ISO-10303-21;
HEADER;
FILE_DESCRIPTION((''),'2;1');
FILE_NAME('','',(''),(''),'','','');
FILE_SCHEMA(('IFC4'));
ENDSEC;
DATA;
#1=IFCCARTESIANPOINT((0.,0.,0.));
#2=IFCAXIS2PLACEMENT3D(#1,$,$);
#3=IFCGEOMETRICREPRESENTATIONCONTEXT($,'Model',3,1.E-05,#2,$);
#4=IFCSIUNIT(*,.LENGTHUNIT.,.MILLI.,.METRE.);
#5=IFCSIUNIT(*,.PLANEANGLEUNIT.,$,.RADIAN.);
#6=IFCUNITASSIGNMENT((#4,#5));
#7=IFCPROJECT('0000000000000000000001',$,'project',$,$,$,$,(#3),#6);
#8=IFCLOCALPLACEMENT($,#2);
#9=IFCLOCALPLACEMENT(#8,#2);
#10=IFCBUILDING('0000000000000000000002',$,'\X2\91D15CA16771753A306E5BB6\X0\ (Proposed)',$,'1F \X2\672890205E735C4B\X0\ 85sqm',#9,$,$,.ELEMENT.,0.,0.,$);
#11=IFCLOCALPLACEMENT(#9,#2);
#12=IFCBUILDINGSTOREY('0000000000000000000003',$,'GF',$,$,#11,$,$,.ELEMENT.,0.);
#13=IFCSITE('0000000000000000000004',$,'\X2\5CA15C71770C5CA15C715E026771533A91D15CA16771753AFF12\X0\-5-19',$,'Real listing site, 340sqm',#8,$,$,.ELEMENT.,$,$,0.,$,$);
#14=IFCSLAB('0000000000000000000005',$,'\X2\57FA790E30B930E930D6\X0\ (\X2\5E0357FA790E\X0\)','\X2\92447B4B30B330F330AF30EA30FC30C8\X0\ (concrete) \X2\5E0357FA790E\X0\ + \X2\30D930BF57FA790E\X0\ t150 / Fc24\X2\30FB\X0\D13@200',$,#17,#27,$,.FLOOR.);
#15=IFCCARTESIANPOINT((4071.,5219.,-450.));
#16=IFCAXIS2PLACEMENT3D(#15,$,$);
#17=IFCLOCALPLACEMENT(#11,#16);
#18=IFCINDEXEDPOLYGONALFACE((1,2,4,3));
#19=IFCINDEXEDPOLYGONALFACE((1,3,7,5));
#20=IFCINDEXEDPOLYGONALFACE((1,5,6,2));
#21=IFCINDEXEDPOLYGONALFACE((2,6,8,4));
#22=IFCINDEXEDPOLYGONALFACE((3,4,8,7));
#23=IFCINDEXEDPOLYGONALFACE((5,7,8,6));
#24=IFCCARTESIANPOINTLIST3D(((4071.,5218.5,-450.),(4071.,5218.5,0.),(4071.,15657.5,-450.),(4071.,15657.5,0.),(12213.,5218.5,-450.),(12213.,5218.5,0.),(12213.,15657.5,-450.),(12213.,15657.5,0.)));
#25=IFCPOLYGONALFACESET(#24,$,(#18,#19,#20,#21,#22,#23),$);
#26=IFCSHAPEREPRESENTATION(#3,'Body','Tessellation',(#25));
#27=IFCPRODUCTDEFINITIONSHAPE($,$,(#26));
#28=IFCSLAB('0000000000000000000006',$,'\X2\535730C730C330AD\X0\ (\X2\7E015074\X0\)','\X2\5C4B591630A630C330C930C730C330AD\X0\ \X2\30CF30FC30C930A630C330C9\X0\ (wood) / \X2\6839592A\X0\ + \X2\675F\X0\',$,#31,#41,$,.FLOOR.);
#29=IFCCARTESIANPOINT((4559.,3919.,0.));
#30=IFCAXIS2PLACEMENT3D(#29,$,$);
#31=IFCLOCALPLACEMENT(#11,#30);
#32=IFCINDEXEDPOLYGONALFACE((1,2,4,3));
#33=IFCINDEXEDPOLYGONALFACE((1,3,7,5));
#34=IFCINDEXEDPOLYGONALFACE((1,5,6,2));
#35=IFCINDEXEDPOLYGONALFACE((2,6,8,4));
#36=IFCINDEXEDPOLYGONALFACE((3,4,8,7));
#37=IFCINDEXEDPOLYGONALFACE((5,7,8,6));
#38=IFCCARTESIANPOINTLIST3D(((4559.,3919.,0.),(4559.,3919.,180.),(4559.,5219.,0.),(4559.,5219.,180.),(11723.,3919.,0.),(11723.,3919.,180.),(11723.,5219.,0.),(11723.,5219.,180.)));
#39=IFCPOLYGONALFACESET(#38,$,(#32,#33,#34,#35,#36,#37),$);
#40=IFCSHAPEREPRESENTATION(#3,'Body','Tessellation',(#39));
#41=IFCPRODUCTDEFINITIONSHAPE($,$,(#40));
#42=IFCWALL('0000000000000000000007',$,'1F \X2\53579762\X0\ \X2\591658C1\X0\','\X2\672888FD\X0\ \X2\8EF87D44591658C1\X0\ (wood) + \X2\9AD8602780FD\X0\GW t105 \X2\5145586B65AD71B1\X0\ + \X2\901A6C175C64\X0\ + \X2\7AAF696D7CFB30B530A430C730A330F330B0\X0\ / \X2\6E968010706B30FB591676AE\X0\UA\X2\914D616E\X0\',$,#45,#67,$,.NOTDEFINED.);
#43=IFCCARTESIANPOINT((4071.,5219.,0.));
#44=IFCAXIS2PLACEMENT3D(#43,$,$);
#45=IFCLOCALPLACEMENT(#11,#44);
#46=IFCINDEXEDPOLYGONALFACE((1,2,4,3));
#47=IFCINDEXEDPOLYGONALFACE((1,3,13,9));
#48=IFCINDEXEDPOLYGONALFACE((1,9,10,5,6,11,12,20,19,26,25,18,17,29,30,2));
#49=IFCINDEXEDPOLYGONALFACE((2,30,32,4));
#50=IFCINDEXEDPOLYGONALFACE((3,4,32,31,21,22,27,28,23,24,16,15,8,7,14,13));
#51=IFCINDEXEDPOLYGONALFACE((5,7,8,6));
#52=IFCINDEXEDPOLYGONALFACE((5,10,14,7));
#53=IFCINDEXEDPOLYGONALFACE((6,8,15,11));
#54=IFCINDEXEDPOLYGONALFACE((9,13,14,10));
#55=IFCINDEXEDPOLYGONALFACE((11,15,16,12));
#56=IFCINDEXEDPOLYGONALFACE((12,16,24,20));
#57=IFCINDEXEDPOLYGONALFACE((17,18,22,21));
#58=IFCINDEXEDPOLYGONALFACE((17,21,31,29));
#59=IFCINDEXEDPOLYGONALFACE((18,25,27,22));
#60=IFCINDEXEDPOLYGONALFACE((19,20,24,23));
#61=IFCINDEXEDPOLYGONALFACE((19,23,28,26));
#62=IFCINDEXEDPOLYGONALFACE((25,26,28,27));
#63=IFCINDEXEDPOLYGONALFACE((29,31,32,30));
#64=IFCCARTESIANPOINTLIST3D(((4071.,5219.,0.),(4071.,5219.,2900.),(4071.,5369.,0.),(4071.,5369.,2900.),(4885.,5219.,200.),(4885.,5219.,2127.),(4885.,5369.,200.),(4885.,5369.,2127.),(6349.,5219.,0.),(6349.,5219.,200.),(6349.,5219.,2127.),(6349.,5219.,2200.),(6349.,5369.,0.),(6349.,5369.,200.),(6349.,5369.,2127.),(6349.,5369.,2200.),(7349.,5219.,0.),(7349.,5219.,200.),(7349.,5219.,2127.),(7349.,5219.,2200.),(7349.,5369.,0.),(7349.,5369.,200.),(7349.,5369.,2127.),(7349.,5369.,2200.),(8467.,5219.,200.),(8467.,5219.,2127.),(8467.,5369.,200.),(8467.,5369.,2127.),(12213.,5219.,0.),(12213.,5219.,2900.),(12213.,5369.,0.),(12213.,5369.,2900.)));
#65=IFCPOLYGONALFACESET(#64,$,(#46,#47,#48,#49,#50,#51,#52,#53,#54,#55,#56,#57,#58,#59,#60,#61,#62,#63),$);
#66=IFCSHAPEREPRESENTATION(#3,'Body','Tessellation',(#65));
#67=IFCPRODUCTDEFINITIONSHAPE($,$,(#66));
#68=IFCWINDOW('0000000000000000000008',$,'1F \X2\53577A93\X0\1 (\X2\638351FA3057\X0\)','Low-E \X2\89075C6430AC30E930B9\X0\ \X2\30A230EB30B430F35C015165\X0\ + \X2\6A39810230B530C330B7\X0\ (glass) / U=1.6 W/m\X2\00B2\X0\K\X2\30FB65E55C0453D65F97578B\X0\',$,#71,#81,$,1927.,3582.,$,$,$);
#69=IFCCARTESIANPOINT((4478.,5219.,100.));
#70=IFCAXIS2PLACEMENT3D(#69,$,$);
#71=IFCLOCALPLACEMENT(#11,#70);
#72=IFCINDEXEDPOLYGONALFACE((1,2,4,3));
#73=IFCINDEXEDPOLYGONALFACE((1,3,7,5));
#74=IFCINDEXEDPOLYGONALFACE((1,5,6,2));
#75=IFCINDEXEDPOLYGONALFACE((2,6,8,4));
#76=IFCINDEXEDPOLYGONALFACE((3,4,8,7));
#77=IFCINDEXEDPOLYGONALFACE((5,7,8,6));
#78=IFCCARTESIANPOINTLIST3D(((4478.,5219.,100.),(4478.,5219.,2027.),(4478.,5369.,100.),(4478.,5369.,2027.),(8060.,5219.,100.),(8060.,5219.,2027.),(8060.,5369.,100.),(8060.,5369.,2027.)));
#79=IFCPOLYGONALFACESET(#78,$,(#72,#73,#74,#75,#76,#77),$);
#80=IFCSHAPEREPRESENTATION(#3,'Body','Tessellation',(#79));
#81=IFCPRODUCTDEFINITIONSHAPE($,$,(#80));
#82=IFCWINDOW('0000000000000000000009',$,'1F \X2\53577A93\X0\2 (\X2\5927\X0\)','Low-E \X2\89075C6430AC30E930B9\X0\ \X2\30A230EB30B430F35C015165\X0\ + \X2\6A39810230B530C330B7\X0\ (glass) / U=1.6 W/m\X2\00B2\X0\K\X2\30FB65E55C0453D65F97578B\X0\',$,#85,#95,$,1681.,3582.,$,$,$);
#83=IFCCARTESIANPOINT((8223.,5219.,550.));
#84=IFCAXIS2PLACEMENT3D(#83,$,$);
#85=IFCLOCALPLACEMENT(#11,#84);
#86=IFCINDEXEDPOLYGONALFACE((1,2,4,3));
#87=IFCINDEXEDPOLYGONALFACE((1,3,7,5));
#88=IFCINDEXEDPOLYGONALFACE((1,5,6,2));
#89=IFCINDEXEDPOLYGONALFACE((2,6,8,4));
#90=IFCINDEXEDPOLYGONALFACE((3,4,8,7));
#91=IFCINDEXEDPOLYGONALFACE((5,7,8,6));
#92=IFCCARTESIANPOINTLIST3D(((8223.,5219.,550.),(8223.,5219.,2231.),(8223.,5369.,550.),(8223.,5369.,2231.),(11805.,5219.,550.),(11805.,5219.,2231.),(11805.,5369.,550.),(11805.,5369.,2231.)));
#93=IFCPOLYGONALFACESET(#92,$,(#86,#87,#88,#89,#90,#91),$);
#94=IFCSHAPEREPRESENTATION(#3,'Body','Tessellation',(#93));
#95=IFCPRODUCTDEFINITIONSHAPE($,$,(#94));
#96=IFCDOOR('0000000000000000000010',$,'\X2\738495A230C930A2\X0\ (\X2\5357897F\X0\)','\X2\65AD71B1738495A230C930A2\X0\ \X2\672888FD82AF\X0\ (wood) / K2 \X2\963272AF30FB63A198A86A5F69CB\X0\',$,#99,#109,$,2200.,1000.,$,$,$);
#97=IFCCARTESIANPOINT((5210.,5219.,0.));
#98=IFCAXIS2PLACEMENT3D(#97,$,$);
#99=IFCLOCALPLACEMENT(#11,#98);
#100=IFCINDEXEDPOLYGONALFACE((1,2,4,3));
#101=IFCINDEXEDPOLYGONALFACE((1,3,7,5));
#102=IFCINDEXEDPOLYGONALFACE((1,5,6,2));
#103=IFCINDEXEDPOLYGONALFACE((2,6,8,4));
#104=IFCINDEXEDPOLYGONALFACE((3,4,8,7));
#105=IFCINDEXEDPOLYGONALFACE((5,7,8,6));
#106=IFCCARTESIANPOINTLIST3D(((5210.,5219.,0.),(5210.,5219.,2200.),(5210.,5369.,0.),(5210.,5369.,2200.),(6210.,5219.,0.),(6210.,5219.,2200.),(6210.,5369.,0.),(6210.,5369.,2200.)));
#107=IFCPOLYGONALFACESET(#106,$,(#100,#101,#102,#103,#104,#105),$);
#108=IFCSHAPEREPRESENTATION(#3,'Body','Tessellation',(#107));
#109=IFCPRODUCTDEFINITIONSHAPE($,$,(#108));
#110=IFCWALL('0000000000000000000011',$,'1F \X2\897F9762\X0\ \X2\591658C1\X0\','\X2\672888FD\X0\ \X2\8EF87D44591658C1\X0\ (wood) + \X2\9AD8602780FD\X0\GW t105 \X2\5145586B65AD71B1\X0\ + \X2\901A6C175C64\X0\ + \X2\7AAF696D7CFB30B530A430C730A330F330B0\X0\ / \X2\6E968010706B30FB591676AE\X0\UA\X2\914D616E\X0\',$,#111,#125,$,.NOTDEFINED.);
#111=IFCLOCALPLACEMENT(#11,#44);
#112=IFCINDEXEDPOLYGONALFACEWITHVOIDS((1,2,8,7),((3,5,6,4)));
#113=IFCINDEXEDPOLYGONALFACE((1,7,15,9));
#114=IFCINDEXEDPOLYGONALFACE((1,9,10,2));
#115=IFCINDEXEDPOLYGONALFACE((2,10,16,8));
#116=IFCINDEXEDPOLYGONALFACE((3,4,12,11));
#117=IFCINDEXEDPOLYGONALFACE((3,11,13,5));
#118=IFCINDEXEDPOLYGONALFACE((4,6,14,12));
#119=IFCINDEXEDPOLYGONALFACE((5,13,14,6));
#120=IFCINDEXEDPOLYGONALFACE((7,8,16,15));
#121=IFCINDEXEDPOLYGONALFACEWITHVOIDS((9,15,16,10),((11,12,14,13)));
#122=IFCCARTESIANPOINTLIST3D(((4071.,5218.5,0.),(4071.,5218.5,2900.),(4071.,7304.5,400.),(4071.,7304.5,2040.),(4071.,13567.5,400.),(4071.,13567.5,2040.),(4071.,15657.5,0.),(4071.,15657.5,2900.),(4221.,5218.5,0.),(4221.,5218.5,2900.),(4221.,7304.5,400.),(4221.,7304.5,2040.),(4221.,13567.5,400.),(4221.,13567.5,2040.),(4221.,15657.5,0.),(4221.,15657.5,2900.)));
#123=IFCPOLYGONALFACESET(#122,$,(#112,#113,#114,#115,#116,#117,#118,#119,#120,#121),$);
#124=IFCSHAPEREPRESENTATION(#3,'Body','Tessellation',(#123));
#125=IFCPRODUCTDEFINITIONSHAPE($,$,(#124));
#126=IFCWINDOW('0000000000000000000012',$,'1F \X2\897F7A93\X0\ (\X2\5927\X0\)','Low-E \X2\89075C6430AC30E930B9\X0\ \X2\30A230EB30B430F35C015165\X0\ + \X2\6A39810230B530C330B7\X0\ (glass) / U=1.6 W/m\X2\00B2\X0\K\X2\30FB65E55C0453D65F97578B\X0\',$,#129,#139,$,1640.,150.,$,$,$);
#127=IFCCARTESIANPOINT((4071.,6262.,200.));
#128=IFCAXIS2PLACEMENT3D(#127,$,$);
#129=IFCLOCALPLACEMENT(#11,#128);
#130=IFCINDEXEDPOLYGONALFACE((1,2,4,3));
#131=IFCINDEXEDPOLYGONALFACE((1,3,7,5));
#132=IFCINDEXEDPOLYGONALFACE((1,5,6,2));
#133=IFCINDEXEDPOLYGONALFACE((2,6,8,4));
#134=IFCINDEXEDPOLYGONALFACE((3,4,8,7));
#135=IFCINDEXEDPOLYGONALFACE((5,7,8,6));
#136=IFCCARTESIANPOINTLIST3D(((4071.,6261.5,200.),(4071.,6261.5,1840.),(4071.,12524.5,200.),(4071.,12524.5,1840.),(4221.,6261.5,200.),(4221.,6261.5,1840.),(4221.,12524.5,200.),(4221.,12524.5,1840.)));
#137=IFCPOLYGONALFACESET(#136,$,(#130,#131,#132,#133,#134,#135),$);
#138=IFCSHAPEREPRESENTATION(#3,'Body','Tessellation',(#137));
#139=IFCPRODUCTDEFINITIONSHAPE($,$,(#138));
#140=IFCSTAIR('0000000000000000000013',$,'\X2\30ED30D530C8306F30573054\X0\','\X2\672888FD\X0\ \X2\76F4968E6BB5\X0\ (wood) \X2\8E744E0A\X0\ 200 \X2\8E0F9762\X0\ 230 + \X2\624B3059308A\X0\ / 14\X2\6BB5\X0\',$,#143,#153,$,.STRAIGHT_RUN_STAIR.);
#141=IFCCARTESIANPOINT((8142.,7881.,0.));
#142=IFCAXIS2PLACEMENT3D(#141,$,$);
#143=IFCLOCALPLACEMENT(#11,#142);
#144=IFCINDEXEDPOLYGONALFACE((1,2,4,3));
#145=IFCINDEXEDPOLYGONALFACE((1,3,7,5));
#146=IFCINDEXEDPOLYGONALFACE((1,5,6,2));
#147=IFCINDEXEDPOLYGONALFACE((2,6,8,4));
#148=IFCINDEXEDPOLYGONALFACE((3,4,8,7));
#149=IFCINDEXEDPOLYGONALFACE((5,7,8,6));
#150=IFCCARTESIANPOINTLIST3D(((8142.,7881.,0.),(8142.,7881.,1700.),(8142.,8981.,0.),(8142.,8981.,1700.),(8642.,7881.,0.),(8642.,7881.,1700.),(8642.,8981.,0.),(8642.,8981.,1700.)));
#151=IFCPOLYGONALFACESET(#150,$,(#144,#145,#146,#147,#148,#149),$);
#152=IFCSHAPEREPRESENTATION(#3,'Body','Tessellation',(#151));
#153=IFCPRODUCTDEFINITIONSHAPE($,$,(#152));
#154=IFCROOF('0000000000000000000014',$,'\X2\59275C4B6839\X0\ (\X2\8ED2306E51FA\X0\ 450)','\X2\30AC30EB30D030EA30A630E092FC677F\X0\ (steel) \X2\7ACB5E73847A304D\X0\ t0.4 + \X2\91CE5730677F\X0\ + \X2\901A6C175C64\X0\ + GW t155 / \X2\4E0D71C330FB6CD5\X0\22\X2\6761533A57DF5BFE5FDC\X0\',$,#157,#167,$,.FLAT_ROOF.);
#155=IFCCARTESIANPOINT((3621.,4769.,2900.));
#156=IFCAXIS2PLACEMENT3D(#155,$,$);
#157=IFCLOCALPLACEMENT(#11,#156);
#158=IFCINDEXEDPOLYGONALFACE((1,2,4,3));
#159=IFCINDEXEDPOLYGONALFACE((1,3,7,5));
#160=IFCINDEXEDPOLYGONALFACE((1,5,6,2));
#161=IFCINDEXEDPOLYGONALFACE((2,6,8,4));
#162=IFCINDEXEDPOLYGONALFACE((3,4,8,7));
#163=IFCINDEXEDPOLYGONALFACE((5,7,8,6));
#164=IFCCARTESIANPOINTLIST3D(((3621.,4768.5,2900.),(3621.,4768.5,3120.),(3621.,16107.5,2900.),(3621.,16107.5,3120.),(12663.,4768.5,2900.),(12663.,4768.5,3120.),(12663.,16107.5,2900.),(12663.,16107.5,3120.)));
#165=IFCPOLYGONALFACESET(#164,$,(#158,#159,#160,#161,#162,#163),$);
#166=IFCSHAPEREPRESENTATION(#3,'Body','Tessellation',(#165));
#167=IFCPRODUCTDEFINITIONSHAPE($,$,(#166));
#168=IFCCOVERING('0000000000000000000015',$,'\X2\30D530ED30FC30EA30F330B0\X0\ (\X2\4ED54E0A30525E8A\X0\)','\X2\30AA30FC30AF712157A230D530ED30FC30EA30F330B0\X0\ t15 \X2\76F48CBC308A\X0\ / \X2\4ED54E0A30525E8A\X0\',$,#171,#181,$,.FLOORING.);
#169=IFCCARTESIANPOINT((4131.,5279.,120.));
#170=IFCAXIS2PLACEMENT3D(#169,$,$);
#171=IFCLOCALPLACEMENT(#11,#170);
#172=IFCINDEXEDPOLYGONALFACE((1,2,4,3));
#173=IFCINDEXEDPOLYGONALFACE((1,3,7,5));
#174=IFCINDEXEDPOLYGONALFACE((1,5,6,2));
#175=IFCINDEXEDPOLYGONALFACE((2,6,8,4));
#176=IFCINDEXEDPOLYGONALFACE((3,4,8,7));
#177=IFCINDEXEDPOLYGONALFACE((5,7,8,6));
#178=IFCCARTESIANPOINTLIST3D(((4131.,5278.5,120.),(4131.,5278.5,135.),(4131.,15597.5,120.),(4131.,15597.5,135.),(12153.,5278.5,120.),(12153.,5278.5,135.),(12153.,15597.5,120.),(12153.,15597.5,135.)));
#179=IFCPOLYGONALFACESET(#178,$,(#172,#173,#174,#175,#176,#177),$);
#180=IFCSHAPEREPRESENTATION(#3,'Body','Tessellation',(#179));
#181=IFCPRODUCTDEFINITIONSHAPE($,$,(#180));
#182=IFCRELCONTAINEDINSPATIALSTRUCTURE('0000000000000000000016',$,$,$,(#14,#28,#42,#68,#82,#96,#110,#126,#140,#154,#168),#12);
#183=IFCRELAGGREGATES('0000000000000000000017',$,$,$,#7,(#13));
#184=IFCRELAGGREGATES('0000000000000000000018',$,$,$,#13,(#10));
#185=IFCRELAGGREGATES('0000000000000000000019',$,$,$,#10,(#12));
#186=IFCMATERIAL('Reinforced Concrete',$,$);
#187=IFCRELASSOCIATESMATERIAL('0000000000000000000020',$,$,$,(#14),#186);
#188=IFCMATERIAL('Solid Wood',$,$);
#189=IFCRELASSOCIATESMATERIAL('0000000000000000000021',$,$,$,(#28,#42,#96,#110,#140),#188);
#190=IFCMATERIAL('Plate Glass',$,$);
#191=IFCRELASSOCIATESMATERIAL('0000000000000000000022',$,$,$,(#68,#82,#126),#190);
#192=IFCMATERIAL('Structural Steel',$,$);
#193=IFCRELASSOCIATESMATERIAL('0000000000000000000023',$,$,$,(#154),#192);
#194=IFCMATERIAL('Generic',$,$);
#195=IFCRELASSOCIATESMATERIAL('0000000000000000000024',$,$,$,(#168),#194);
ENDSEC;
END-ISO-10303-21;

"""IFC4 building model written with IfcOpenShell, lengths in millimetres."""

from ifc_helpers import new_model, si_unit, frame, frame_2d, origin, place, context, project, spatial, rectangle, extrude, material, element, fill, save


model = new_model("IFC4")

# Units and contexts
model_context = context("Model", 3, precision=1e-05, world=origin())
ifc_project = project(units=[si_unit("LENGTHUNIT", "METRE", prefix="MILLI"), si_unit("PLANEANGLEUNIT", "RADIAN")], contexts=[model_context])

# Site, building, storey
site_placement = place(None, origin())
site = spatial("IfcSite", under=ifc_project, at=site_placement, Name="岡山県岡山市東区金岡東町２-5-19", ObjectType="Real listing site, 340sqm", CompositionType="ELEMENT", RefElevation=0.0)
building_placement = place(site_placement, origin())
building = spatial("IfcBuilding", under=site, at=building_placement, Name="金岡東町の家 (Proposed)", ObjectType="1F 木造平屋 85sqm", CompositionType="ELEMENT", ElevationOfRefHeight=0.0, ElevationOfTerrain=0.0)
storey_placement = place(building_placement, origin())
storey = spatial("IfcBuildingStorey", under=building, at=storey_placement, Name="GF", CompositionType="ELEMENT", Elevation=0.0)

# Slabs
ifc_material_1 = material(Name="Reinforced Concrete")
slab_1_placement = place(storey_placement, frame((4071.0, 5219.0, -450.0)))
element("IfcSlab", 1, at=slab_1_placement, inside=storey, material=ifc_material_1, Name="基礎スラブ (布基礎)", Description="鉄筋コンクリート (concrete) 布基礎 + ベタ基礎 t150 / Fc24・D13@200", PredefinedType="FLOOR", context=model_context, shape_type="SweptSolid", body=[
    extrude(rectangle(XDim=8142.0, YDim=10439.0, at=frame_2d((4071.0, 5219.0))), frame((4071.0, 5219.0, -450.0)), (0.0, 0.0, 1.0), 450.0),
])
ifc_material_2 = material(Name="Solid Wood")
slab_2_placement = place(storey_placement, frame((4559.0, 3919.0, 0.0)))
element("IfcSlab", 2, at=slab_2_placement, inside=storey, material=ifc_material_2, Name="南デッキ (縁側)", Description="屋外ウッドデッキ ハードウッド (wood) / 根太 + 束", PredefinedType="FLOOR", context=model_context, shape_type="SweptSolid", body=[
    extrude(rectangle(XDim=7164.0, YDim=1300.0, at=frame_2d((3582.0, 650.0))), frame((4559.0, 3919.0, 0.0)), (0.0, 0.0, 1.0), 180.0),
])

# Wall, openings, windows, door
wall_1_placement = place(storey_placement, frame((4071.0, 5219.0, 0.0)))
wall_1 = element("IfcWall", 3, at=wall_1_placement, inside=storey, material=ifc_material_2, Name="1F 南面 外壁", Description="木製 軸組外壁 (wood) + 高性能GW t105 充填断熱 + 通気層 + 窯業系サイディング / 準耐火・外皮UA配慮", PredefinedType="NOTDEFINED", context=model_context, shape_type="SweptSolid", body=[
    extrude(rectangle(XDim=8142.0, YDim=150.0, at=frame_2d((4071.0, 75.0))), frame((4071.0, 5219.0, 0.0)), (0.0, 0.0, 1.0), 2900.0),
])
opening_1_placement = place(storey_placement, frame((4478.0, 5219.0, 100.0)))
opening_1 = element("IfcOpeningElement", 4, at=opening_1_placement, cuts=wall_1, PredefinedType="NOTDEFINED", context=model_context, shape_type="SweptSolid", body=[
    extrude(rectangle(XDim=3582.0, YDim=150.0, at=frame_2d((1791.0, 75.0))), frame((4478.0, 5219.0, 100.0)), (0.0, 0.0, 1.0), 1927.0),
])
opening_2_placement = place(storey_placement, frame((8223.0, 5219.0, 550.0)))
opening_2 = element("IfcOpeningElement", 5, at=opening_2_placement, cuts=wall_1, PredefinedType="NOTDEFINED", context=model_context, shape_type="SweptSolid", body=[
    extrude(rectangle(XDim=3582.0, YDim=150.0, at=frame_2d((1791.0, 75.0))), frame((8223.0, 5219.0, 550.0)), (0.0, 0.0, 1.0), 1681.0),
])
opening_3_placement = place(storey_placement, frame((5210.0, 5219.0, 0.0)))
opening_3 = element("IfcOpeningElement", 6, at=opening_3_placement, cuts=wall_1, PredefinedType="NOTDEFINED", context=model_context, shape_type="SweptSolid", body=[
    extrude(rectangle(XDim=1000.0, YDim=150.0, at=frame_2d((500.0, 75.0))), frame((5210.0, 5219.0, 0.0)), (0.0, 0.0, 1.0), 2200.0),
])
ifc_material_3 = material(Name="Plate Glass")
window_1_placement = place(storey_placement, frame((4478.0, 5219.0, 100.0)))
window_1 = element("IfcWindow", 7, at=window_1_placement, inside=storey, material=ifc_material_3, Name="1F 南窓1 (掃出し)", Description="Low-E 複層ガラス アルゴン封入 + 樹脂サッシ (glass) / U=1.6 W/m²K・日射取得型", OverallHeight=1927.0, OverallWidth=3582.0, context=model_context, shape_type="SweptSolid", body=[
    extrude(rectangle(XDim=3582.0, YDim=150.0, at=frame_2d((1791.0, 75.0))), frame((4478.0, 5219.0, 100.0)), (0.0, 0.0, 1.0), 1927.0),
])
fill(opening_1, window_1)
window_2_placement = place(storey_placement, frame((8223.0, 5219.0, 550.0)))
window_2 = element("IfcWindow", 8, at=window_2_placement, inside=storey, material=ifc_material_3, Name="1F 南窓2 (大)", Description="Low-E 複層ガラス アルゴン封入 + 樹脂サッシ (glass) / U=1.6 W/m²K・日射取得型", OverallHeight=1681.0, OverallWidth=3582.0, context=model_context, shape_type="SweptSolid", body=[
    extrude(rectangle(XDim=3582.0, YDim=150.0, at=frame_2d((1791.0, 75.0))), frame((8223.0, 5219.0, 550.0)), (0.0, 0.0, 1.0), 1681.0),
])
fill(opening_2, window_2)
door_placement = place(storey_placement, frame((5210.0, 5219.0, 0.0)))
door = element("IfcDoor", 9, at=door_placement, inside=storey, material=ifc_material_2, Name="玄関ドア (南西)", Description="断熱玄関ドア 木製芯 (wood) / K2 防犯・採風機構", OverallHeight=2200.0, OverallWidth=1000.0, context=model_context, shape_type="SweptSolid", body=[
    extrude(rectangle(XDim=1000.0, YDim=150.0, at=frame_2d((500.0, 75.0))), frame((5210.0, 5219.0, 0.0)), (0.0, 0.0, 1.0), 2200.0),
])
fill(opening_3, door)

# Wall, opening, window
wall_2_placement = place(storey_placement, frame((4071.0, 5219.0, 0.0)))
wall_2 = element("IfcWall", 10, at=wall_2_placement, inside=storey, material=ifc_material_2, Name="1F 西面 外壁", Description="木製 軸組外壁 (wood) + 高性能GW t105 充填断熱 + 通気層 + 窯業系サイディング / 準耐火・外皮UA配慮", PredefinedType="NOTDEFINED", context=model_context, shape_type="SweptSolid", body=[
    extrude(rectangle(XDim=150.0, YDim=10439.0, at=frame_2d((75.0, 5219.0))), frame((4071.0, 5219.0, 0.0)), (0.0, 0.0, 1.0), 2900.0),
])
opening_4_placement = place(storey_placement, frame((4071.0, 6262.0, 200.0)))
opening_4 = element("IfcOpeningElement", 11, at=opening_4_placement, cuts=wall_2, PredefinedType="NOTDEFINED", context=model_context, shape_type="SweptSolid", body=[
    extrude(rectangle(XDim=150.0, YDim=6263.0, at=frame_2d((75.0, 3131.0))), frame((4071.0, 6262.0, 200.0)), (0.0, 0.0, 1.0), 1640.0),
])
window_3_placement = place(storey_placement, frame((4071.0, 6262.0, 200.0)))
window_3 = element("IfcWindow", 12, at=window_3_placement, inside=storey, material=ifc_material_3, Name="1F 西窓 (大)", Description="Low-E 複層ガラス アルゴン封入 + 樹脂サッシ (glass) / U=1.6 W/m²K・日射取得型", OverallHeight=1640.0, OverallWidth=150.0, context=model_context, shape_type="SweptSolid", body=[
    extrude(rectangle(XDim=150.0, YDim=6263.0, at=frame_2d((75.0, 3131.0))), frame((4071.0, 6262.0, 200.0)), (0.0, 0.0, 1.0), 1640.0),
])
fill(opening_4, window_3)

# Stair
stair_placement = place(storey_placement, frame((8142.0, 7881.0, 0.0)))
element("IfcStair", 13, at=stair_placement, inside=storey, material=ifc_material_2, Name="ロフトはしご", Description="木製 直階段 (wood) 蹴上 200 踏面 230 + 手すり / 14段", PredefinedType="STRAIGHT_RUN_STAIR", context=model_context, shape_type="SweptSolid", body=[
    extrude(rectangle(XDim=500.0, YDim=1100.0, at=frame_2d((250.0, 550.0))), frame((8142.0, 7881.0, 0.0)), (0.0, 0.0, 1.0), 1700.0),
])

# Roof
ifc_material_4 = material(Name="Structural Steel")
roof_placement = place(storey_placement, frame((3621.0, 4769.0, 2900.0)))
element("IfcRoof", 14, at=roof_placement, inside=storey, material=ifc_material_4, Name="大屋根 (軒の出 450)", Description="ガルバリウム鋼板 (steel) 立平葺き t0.4 + 野地板 + 通気層 + GW t155 / 不燃・法22条区域対応", PredefinedType="FLAT_ROOF", context=model_context, shape_type="SweptSolid", body=[
    extrude(rectangle(XDim=9042.0, YDim=11339.0, at=frame_2d((4521.0, 5669.0))), frame((3621.0, 4769.0, 2900.0)), (0.0, 0.0, 1.0), 220.0),
])

# Covering
ifc_material_5 = material(Name="Generic")
covering_placement = place(storey_placement, frame((4131.0, 5279.0, 120.0)))
element("IfcCovering", 15, at=covering_placement, inside=storey, material=ifc_material_5, Name="フローリング (仕上げ床)", Description="オーク無垢フローリング t15 直貼り / 仕上げ床", PredefinedType="FLOORING", context=model_context, shape_type="SweptSolid", body=[
    extrude(rectangle(XDim=8022.0, YDim=10319.0, at=frame_2d((4011.0, 5159.0))), frame((4131.0, 5279.0, 120.0)), (0.0, 0.0, 1.0), 15.0),
])

save(model, "model.ifc")
